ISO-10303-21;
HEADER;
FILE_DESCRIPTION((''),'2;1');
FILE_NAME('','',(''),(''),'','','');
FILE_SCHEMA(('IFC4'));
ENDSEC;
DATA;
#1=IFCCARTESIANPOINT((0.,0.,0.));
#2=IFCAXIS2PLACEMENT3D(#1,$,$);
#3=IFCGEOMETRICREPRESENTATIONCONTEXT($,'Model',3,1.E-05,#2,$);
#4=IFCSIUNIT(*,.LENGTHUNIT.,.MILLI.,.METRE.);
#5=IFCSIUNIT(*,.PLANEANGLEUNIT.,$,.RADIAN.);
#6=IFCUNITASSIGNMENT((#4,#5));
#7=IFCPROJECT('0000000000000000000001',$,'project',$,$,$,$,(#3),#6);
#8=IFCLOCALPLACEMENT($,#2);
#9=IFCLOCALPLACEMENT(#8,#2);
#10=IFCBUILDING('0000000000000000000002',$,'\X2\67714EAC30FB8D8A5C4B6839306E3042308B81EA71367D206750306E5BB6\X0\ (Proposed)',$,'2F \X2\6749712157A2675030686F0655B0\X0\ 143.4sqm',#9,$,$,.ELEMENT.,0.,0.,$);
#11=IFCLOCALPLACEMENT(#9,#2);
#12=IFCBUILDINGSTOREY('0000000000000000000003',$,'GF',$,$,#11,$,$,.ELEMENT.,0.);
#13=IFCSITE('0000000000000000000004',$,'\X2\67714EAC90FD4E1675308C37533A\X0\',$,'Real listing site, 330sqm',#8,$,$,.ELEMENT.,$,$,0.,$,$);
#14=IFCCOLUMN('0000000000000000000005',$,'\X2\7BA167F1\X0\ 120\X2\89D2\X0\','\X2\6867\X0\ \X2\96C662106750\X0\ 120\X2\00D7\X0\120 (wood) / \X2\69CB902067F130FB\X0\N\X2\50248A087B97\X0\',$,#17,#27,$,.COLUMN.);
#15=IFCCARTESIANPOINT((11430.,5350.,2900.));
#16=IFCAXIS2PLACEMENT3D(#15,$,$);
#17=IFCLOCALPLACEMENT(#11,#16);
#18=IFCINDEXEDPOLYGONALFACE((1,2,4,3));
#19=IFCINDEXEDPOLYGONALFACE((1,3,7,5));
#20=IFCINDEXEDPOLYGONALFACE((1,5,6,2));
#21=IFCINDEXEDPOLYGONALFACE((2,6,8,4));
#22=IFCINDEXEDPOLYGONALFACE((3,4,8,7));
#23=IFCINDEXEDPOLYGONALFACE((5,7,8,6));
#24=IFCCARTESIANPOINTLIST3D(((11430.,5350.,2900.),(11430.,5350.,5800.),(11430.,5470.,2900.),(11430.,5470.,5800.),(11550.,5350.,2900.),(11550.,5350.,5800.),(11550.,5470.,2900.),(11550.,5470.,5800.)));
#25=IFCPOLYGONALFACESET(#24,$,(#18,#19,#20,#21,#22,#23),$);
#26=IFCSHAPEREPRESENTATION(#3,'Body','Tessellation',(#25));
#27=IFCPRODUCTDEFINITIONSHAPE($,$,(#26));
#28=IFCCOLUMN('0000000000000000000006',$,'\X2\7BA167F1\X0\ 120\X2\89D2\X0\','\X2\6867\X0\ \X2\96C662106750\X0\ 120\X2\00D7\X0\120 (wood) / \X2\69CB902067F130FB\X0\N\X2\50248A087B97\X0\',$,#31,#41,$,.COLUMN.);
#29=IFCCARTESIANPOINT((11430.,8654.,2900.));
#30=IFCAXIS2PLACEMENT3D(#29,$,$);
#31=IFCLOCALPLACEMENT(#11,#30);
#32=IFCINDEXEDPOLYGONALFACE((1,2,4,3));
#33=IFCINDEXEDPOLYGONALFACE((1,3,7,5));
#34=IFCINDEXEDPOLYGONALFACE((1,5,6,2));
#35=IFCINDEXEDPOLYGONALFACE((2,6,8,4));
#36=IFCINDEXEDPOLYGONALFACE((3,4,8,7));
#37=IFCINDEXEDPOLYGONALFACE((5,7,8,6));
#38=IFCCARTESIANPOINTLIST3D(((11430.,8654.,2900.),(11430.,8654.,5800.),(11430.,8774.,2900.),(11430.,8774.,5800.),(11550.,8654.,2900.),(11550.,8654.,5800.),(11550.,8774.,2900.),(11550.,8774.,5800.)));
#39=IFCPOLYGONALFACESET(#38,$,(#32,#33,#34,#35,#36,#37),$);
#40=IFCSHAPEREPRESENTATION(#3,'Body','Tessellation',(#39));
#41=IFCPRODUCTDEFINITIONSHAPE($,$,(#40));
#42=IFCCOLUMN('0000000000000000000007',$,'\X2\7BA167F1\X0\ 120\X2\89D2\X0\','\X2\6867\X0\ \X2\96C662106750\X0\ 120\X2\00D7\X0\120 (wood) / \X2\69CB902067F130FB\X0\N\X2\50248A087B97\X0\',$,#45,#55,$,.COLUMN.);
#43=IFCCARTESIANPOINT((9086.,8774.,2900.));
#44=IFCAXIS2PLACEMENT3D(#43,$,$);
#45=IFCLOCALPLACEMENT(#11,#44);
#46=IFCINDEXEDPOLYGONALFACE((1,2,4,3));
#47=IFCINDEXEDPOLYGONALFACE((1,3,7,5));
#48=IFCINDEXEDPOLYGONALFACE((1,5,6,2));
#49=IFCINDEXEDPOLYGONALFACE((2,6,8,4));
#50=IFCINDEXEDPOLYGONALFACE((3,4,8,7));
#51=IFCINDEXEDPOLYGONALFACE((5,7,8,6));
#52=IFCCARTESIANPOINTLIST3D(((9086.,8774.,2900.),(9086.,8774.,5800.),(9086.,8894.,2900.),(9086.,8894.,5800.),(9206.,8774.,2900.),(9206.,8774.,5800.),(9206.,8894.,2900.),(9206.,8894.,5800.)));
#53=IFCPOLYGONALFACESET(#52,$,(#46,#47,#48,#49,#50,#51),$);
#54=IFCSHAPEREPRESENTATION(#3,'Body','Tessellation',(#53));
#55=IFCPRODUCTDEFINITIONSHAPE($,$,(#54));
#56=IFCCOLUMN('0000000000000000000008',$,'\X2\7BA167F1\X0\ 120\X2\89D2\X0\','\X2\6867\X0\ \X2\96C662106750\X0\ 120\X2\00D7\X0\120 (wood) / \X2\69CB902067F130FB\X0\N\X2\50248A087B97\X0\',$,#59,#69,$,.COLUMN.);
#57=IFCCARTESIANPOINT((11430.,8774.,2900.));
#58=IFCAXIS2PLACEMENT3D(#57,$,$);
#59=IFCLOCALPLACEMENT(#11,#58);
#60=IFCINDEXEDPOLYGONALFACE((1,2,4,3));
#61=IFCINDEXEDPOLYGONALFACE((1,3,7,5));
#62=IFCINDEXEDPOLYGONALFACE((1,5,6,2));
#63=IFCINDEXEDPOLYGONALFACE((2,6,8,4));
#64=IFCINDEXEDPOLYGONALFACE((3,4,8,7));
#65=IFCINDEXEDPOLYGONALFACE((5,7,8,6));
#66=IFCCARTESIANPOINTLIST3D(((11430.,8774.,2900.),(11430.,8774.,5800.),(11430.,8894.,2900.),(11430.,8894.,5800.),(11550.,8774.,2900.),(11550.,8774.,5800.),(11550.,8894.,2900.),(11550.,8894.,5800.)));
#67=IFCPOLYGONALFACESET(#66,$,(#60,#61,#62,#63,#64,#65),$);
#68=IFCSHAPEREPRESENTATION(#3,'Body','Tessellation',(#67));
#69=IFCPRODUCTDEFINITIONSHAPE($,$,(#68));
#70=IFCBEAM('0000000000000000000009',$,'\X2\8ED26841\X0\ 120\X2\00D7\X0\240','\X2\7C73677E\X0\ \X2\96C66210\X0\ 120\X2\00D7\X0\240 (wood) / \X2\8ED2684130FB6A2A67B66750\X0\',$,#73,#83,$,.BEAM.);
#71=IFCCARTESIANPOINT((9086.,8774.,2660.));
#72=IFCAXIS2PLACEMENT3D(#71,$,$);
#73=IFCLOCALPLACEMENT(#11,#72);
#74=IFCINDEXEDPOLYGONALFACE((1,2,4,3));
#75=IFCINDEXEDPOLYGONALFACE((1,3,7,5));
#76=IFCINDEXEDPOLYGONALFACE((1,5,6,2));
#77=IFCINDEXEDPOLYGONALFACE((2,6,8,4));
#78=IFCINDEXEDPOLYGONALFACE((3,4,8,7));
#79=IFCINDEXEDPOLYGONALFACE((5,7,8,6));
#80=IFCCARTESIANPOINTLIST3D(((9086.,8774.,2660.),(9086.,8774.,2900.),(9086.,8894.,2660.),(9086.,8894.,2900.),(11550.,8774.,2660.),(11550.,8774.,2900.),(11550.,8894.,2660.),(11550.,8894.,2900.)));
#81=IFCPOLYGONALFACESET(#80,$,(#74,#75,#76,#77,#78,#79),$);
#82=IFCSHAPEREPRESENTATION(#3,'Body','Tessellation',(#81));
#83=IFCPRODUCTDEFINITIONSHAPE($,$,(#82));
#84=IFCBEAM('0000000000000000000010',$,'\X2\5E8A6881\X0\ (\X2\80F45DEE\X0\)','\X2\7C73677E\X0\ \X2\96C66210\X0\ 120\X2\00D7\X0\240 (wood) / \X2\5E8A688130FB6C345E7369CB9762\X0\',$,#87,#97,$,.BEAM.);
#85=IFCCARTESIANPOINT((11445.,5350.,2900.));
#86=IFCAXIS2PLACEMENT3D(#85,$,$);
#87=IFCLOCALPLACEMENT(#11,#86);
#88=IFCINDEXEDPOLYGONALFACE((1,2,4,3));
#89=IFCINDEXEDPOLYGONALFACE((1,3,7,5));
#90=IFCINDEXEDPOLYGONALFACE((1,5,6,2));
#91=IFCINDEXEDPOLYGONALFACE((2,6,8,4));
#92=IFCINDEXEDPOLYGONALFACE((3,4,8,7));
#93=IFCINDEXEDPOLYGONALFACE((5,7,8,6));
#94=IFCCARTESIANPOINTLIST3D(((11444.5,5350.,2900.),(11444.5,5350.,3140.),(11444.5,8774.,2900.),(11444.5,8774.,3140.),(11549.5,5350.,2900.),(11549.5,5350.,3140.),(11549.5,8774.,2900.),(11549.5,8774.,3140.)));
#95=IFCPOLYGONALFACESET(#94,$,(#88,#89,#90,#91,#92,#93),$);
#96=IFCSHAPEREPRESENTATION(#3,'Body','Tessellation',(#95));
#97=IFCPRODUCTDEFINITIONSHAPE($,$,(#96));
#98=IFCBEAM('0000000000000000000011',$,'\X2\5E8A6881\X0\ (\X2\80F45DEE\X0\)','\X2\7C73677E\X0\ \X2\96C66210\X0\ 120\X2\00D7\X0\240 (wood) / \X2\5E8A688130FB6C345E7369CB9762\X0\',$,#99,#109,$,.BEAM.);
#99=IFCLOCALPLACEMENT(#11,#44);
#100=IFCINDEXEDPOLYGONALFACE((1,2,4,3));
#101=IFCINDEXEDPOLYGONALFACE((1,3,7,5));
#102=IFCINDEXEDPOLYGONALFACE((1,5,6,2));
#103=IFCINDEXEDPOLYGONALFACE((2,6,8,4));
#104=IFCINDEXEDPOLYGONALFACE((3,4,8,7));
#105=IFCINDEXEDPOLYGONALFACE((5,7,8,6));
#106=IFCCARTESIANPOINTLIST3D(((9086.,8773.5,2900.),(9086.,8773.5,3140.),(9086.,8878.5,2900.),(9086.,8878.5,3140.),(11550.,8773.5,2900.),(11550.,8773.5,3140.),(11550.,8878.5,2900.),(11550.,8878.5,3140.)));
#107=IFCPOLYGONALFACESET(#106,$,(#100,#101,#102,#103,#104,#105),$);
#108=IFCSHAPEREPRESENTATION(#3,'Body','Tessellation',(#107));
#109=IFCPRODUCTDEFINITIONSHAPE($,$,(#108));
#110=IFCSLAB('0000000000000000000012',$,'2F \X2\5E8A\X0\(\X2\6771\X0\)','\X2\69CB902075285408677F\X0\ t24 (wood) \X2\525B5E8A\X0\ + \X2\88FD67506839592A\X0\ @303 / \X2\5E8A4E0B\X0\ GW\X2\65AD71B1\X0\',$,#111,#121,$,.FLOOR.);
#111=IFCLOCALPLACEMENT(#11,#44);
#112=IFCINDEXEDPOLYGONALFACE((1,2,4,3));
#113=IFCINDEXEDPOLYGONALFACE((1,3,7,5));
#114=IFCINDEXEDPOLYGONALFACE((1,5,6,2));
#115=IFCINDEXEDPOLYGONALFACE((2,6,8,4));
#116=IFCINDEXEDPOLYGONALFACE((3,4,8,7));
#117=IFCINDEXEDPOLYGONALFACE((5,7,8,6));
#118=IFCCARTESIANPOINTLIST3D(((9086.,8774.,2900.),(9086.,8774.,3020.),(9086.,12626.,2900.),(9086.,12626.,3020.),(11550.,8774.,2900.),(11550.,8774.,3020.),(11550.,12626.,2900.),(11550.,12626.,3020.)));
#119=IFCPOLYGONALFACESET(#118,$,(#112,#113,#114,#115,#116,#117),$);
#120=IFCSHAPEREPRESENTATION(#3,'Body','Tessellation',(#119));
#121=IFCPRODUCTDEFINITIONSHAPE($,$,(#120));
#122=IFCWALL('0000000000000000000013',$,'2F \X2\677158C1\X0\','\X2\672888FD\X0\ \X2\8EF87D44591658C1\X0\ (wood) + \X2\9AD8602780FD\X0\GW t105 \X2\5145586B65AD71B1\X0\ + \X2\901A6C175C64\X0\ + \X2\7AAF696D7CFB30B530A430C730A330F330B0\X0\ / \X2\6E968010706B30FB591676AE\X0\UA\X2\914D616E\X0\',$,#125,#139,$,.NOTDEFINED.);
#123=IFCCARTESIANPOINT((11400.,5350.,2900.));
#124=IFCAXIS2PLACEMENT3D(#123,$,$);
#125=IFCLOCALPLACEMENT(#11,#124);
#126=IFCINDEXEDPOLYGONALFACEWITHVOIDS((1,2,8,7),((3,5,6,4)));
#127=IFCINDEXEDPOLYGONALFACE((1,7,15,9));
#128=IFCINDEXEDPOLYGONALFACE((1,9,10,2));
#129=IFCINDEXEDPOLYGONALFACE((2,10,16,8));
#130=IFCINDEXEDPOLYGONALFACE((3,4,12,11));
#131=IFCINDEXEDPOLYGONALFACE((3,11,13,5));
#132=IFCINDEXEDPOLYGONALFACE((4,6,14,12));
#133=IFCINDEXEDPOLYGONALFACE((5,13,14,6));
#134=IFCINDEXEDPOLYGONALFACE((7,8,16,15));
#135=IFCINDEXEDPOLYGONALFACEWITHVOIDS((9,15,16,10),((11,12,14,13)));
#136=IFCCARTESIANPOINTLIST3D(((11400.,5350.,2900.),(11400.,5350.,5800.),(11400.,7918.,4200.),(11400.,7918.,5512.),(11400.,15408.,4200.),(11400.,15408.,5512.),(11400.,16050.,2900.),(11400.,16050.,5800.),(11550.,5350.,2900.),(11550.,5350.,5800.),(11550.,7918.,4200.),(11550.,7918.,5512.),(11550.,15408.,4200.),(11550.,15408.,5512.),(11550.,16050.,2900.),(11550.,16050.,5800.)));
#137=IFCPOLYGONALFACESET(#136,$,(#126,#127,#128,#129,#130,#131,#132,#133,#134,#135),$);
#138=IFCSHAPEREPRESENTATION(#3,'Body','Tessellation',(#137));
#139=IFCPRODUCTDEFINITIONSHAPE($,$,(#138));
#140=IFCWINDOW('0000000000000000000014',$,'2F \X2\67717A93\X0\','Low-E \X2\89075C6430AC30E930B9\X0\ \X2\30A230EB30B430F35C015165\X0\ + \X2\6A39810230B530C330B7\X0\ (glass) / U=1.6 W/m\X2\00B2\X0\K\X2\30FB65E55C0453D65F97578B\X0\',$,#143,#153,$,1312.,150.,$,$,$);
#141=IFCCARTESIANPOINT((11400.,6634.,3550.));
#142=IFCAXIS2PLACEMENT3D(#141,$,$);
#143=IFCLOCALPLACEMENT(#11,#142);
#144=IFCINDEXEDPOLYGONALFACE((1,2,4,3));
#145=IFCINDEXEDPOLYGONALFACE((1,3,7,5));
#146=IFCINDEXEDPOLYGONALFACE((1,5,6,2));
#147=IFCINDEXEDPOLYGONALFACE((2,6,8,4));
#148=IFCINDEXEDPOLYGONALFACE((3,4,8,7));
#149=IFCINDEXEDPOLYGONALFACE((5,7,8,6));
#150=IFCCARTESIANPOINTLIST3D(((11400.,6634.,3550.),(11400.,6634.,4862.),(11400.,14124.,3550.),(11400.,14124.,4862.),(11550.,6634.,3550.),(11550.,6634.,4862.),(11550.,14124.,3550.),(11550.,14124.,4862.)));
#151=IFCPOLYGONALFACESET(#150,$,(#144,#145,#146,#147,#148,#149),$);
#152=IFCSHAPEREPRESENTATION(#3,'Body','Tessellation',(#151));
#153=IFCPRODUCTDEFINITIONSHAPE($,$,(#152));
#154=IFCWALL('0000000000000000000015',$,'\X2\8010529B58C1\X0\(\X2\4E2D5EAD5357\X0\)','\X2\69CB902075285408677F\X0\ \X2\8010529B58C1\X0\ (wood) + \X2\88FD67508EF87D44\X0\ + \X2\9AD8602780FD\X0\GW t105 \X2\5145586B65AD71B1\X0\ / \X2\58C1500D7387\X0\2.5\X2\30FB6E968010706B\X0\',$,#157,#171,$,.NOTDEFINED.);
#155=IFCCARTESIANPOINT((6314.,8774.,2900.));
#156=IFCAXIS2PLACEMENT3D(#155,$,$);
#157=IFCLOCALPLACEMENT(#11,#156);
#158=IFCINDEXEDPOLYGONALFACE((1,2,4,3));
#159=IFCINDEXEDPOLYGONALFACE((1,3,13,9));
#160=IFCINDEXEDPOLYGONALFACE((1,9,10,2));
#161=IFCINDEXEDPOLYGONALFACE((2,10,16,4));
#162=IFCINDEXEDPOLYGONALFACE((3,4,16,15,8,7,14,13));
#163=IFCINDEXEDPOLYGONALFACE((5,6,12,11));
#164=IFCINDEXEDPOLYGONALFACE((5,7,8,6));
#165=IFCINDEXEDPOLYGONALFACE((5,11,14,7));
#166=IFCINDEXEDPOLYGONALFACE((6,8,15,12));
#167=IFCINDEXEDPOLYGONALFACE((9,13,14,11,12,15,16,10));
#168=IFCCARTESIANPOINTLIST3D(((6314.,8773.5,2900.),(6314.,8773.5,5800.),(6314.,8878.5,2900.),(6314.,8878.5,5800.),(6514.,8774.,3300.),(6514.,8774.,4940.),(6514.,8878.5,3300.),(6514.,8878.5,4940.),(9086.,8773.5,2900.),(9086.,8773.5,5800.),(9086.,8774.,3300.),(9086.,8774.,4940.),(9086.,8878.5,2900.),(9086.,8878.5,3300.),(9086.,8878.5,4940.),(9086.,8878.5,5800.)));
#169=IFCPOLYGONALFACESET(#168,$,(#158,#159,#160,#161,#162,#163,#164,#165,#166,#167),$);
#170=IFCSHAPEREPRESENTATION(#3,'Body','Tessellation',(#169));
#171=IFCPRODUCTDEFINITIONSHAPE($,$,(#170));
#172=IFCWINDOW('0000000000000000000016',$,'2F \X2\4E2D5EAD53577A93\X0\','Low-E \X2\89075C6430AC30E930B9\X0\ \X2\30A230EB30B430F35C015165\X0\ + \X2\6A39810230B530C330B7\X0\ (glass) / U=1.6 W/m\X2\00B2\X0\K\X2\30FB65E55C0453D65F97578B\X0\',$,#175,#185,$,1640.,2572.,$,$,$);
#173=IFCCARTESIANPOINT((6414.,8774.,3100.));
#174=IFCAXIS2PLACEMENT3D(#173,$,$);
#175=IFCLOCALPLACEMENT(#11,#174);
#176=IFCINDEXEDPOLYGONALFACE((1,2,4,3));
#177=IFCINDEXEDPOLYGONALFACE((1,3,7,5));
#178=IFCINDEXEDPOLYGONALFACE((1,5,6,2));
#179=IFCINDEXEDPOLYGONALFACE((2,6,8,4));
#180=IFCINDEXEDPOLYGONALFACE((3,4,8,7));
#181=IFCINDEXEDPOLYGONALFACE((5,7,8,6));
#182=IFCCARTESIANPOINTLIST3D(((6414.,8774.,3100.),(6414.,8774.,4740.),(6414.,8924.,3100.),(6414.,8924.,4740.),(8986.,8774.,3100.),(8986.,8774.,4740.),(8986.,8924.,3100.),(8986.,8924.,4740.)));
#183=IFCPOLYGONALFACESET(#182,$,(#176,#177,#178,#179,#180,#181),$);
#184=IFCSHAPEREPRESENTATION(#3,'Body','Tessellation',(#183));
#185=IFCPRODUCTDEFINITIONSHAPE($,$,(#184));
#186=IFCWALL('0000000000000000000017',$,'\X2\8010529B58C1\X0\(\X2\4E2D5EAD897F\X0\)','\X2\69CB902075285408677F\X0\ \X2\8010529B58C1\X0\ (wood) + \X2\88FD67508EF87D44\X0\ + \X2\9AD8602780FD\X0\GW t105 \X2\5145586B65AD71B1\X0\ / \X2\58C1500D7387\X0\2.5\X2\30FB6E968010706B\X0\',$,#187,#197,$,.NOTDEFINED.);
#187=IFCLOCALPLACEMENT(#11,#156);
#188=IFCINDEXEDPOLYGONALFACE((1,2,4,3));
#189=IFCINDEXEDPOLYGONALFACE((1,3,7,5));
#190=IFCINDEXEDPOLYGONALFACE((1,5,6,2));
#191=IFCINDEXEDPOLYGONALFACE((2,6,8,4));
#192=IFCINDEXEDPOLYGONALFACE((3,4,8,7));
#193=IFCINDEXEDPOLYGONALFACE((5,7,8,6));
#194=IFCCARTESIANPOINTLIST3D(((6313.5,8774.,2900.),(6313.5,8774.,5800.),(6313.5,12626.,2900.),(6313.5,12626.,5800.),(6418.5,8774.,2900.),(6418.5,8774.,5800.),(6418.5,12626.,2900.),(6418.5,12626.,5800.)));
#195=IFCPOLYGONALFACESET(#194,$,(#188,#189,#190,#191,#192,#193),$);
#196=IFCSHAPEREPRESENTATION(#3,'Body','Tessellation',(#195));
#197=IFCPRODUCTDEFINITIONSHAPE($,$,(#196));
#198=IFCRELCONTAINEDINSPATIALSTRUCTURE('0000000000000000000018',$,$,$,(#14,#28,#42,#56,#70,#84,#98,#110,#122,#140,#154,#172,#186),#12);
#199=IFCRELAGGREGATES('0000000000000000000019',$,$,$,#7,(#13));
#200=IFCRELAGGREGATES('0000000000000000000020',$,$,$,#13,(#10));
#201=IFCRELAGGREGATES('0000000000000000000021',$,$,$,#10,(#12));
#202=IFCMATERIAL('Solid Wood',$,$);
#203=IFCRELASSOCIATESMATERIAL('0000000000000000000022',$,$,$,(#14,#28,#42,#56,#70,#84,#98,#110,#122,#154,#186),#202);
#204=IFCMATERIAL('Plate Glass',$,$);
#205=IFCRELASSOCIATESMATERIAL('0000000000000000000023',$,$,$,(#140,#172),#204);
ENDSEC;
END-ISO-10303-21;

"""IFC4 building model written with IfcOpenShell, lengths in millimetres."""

from ifc_helpers import new_model, si_unit, frame, frame_2d, origin, place, context, project, spatial, rectangle, extrude, material, element, fill, save


model = new_model("IFC4")

# Units and contexts
model_context = context("Model", 3, precision=1e-05, world=origin())
ifc_project = project(units=[si_unit("LENGTHUNIT", "METRE", prefix="MILLI"), si_unit("PLANEANGLEUNIT", "RADIAN")], contexts=[model_context])

# Site, building, storey
site_placement = place(None, origin())
site = spatial("IfcSite", under=ifc_project, at=site_placement, Name="東京都世田谷区", ObjectType="Real listing site, 330sqm", CompositionType="ELEMENT", RefElevation=0.0)
building_placement = place(site_placement, origin())
building = spatial("IfcBuilding", under=site, at=building_placement, Name="東京・越屋根のある自然素材の家 (Proposed)", ObjectType="2F 杉無垢材と漆喰 143.4sqm", CompositionType="ELEMENT", ElevationOfRefHeight=0.0, ElevationOfTerrain=0.0)
storey_placement = place(building_placement, origin())
storey = spatial("IfcBuildingStorey", under=building, at=storey_placement, Name="GF", CompositionType="ELEMENT", Elevation=0.0)

# Columns
ifc_material_1 = material(Name="Solid Wood")
column_1_placement = place(storey_placement, frame((11430.0, 5350.0, 2900.0)))
element("IfcColumn", 1, at=column_1_placement, inside=storey, material=ifc_material_1, Name="管柱 120角", Description="桧 集成材 120×120 (wood) / 構造柱・N値計算", PredefinedType="COLUMN", context=model_context, shape_type="SweptSolid", body=[
    extrude(rectangle(XDim=120.0, YDim=120.0, at=frame_2d((60.0, 60.0))), frame((11430.0, 5350.0, 2900.0)), (0.0, 0.0, 1.0), 2900.0),
])
column_2_placement = place(storey_placement, frame((11430.0, 8654.0, 2900.0)))
element("IfcColumn", 2, at=column_2_placement, inside=storey, material=ifc_material_1, Name="管柱 120角", Description="桧 集成材 120×120 (wood) / 構造柱・N値計算", PredefinedType="COLUMN", context=model_context, shape_type="SweptSolid", body=[
    extrude(rectangle(XDim=120.0, YDim=120.0, at=frame_2d((60.0, 60.0))), frame((11430.0, 8654.0, 2900.0)), (0.0, 0.0, 1.0), 2900.0),
])
column_3_placement = place(storey_placement, frame((9086.0, 8774.0, 2900.0)))
element("IfcColumn", 3, at=column_3_placement, inside=storey, material=ifc_material_1, Name="管柱 120角", Description="桧 集成材 120×120 (wood) / 構造柱・N値計算", PredefinedType="COLUMN", context=model_context, shape_type="SweptSolid", body=[
    extrude(rectangle(XDim=120.0, YDim=120.0, at=frame_2d((60.0, 60.0))), frame((9086.0, 8774.0, 2900.0)), (0.0, 0.0, 1.0), 2900.0),
])
column_4_placement = place(storey_placement, frame((11430.0, 8774.0, 2900.0)))
element("IfcColumn", 4, at=column_4_placement, inside=storey, material=ifc_material_1, Name="管柱 120角", Description="桧 集成材 120×120 (wood) / 構造柱・N値計算", PredefinedType="COLUMN", context=model_context, shape_type="SweptSolid", body=[
    extrude(rectangle(XDim=120.0, YDim=120.0, at=frame_2d((60.0, 60.0))), frame((11430.0, 8774.0, 2900.0)), (0.0, 0.0, 1.0), 2900.0),
])

# Beams
beam_1_placement = place(storey_placement, frame((9086.0, 8774.0, 2660.0)))
element("IfcBeam", 5, at=beam_1_placement, inside=storey, material=ifc_material_1, Name="軒桁 120×240", Description="米松 集成 120×240 (wood) / 軒桁・横架材", PredefinedType="BEAM", context=model_context, shape_type="SweptSolid", body=[
    extrude(rectangle(XDim=2464.0, YDim=120.0, at=frame_2d((1232.0, 60.0))), frame((9086.0, 8774.0, 2660.0)), (0.0, 0.0, 1.0), 240.0),
])
beam_2_placement = place(storey_placement, frame((11445.0, 5350.0, 2900.0)))
element("IfcBeam", 6, at=beam_2_placement, inside=storey, material=ifc_material_1, Name="床梁 (胴差)", Description="米松 集成 120×240 (wood) / 床梁・水平構面", PredefinedType="BEAM", context=model_context, shape_type="SweptSolid", body=[
    extrude(rectangle(XDim=105.0, YDim=3424.0, at=frame_2d((52.0, 1712.0))), frame((11445.0, 5350.0, 2900.0)), (0.0, 0.0, 1.0), 240.0),
])
beam_3_placement = place(storey_placement, frame((9086.0, 8774.0, 2900.0)))
element("IfcBeam", 7, at=beam_3_placement, inside=storey, material=ifc_material_1, Name="床梁 (胴差)", Description="米松 集成 120×240 (wood) / 床梁・水平構面", PredefinedType="BEAM", context=model_context, shape_type="SweptSolid", body=[
    extrude(rectangle(XDim=2464.0, YDim=105.0, at=frame_2d((1232.0, 52.0))), frame((9086.0, 8774.0, 2900.0)), (0.0, 0.0, 1.0), 240.0),
])

# Slab
slab_placement = place(storey_placement, frame((9086.0, 8774.0, 2900.0)))
element("IfcSlab", 8, at=slab_placement, inside=storey, material=ifc_material_1, Name="2F 床(東)", Description="構造用合板 t24 (wood) 剛床 + 製材根太 @303 / 床下 GW断熱", PredefinedType="FLOOR", context=model_context, shape_type="SweptSolid", body=[
    extrude(rectangle(XDim=2464.0, YDim=3852.0, at=frame_2d((1232.0, 1926.0))), frame((9086.0, 8774.0, 2900.0)), (0.0, 0.0, 1.0), 120.0),
])

# Walls, openings, windows
wall_1_placement = place(storey_placement, frame((11400.0, 5350.0, 2900.0)))
wall_1 = element("IfcWall", 9, at=wall_1_placement, inside=storey, material=ifc_material_1, Name="2F 東壁", Description="木製 軸組外壁 (wood) + 高性能GW t105 充填断熱 + 通気層 + 窯業系サイディング / 準耐火・外皮UA配慮", PredefinedType="NOTDEFINED", context=model_context, shape_type="SweptSolid", body=[
    extrude(rectangle(XDim=150.0, YDim=10700.0, at=frame_2d((75.0, 5350.0))), frame((11400.0, 5350.0, 2900.0)), (0.0, 0.0, 1.0), 2900.0),
])
opening_1_placement = place(storey_placement, frame((11400.0, 6634.0, 3550.0)))
opening_1 = element("IfcOpeningElement", 10, at=opening_1_placement, cuts=wall_1, PredefinedType="NOTDEFINED", context=model_context, shape_type="SweptSolid", body=[
    extrude(rectangle(XDim=150.0, YDim=7490.0, at=frame_2d((75.0, 3745.0))), frame((11400.0, 6634.0, 3550.0)), (0.0, 0.0, 1.0), 1312.0),
])
ifc_material_2 = material(Name="Plate Glass")
window_1_placement = place(storey_placement, frame((11400.0, 6634.0, 3550.0)))
window_1 = element("IfcWindow", 11, at=window_1_placement, inside=storey, material=ifc_material_2, Name="2F 東窓", Description="Low-E 複層ガラス アルゴン封入 + 樹脂サッシ (glass) / U=1.6 W/m²K・日射取得型", OverallHeight=1312.0, OverallWidth=150.0, context=model_context, shape_type="SweptSolid", body=[
    extrude(rectangle(XDim=150.0, YDim=7490.0, at=frame_2d((75.0, 3745.0))), frame((11400.0, 6634.0, 3550.0)), (0.0, 0.0, 1.0), 1312.0),
])
fill(opening_1, window_1)
wall_2_placement = place(storey_placement, frame((6314.0, 8774.0, 2900.0)))
wall_2 = element("IfcWall", 12, at=wall_2_placement, inside=storey, material=ifc_material_1, Name="耐力壁(中庭南)", Description="構造用合板 耐力壁 (wood) + 製材軸組 + 高性能GW t105 充填断熱 / 壁倍率2.5・準耐火", PredefinedType="NOTDEFINED", context=model_context, shape_type="SweptSolid", body=[
    extrude(rectangle(XDim=2772.0, YDim=105.0, at=frame_2d((1386.0, 52.0))), frame((6314.0, 8774.0, 2900.0)), (0.0, 0.0, 1.0), 2900.0),
])
opening_2_placement = place(storey_placement, frame((6414.0, 8774.0, 3100.0)))
opening_2 = element("IfcOpeningElement", 13, at=opening_2_placement, cuts=wall_2, PredefinedType="NOTDEFINED", context=model_context, shape_type="SweptSolid", body=[
    extrude(rectangle(XDim=2572.0, YDim=150.0, at=frame_2d((1286.0, 75.0))), frame((6414.0, 8774.0, 3100.0)), (0.0, 0.0, 1.0), 1640.0),
])
window_2_placement = place(storey_placement, frame((6414.0, 8774.0, 3100.0)))
window_2 = element("IfcWindow", 14, at=window_2_placement, inside=storey, material=ifc_material_2, Name="2F 中庭南窓", Description="Low-E 複層ガラス アルゴン封入 + 樹脂サッシ (glass) / U=1.6 W/m²K・日射取得型", OverallHeight=1640.0, OverallWidth=2572.0, context=model_context, shape_type="SweptSolid", body=[
    extrude(rectangle(XDim=2572.0, YDim=150.0, at=frame_2d((1286.0, 75.0))), frame((6414.0, 8774.0, 3100.0)), (0.0, 0.0, 1.0), 1640.0),
])
fill(opening_2, window_2)

# Wall
wall_3_placement = place(storey_placement, frame((6314.0, 8774.0, 2900.0)))
element("IfcWall", 15, at=wall_3_placement, inside=storey, material=ifc_material_1, Name="耐力壁(中庭西)", Description="構造用合板 耐力壁 (wood) + 製材軸組 + 高性能GW t105 充填断熱 / 壁倍率2.5・準耐火", PredefinedType="NOTDEFINED", context=model_context, shape_type="SweptSolid", body=[
    extrude(rectangle(XDim=105.0, YDim=3852.0, at=frame_2d((52.0, 1926.0))), frame((6314.0, 8774.0, 2900.0)), (0.0, 0.0, 1.0), 2900.0),
])

save(model, "model.ifc")
